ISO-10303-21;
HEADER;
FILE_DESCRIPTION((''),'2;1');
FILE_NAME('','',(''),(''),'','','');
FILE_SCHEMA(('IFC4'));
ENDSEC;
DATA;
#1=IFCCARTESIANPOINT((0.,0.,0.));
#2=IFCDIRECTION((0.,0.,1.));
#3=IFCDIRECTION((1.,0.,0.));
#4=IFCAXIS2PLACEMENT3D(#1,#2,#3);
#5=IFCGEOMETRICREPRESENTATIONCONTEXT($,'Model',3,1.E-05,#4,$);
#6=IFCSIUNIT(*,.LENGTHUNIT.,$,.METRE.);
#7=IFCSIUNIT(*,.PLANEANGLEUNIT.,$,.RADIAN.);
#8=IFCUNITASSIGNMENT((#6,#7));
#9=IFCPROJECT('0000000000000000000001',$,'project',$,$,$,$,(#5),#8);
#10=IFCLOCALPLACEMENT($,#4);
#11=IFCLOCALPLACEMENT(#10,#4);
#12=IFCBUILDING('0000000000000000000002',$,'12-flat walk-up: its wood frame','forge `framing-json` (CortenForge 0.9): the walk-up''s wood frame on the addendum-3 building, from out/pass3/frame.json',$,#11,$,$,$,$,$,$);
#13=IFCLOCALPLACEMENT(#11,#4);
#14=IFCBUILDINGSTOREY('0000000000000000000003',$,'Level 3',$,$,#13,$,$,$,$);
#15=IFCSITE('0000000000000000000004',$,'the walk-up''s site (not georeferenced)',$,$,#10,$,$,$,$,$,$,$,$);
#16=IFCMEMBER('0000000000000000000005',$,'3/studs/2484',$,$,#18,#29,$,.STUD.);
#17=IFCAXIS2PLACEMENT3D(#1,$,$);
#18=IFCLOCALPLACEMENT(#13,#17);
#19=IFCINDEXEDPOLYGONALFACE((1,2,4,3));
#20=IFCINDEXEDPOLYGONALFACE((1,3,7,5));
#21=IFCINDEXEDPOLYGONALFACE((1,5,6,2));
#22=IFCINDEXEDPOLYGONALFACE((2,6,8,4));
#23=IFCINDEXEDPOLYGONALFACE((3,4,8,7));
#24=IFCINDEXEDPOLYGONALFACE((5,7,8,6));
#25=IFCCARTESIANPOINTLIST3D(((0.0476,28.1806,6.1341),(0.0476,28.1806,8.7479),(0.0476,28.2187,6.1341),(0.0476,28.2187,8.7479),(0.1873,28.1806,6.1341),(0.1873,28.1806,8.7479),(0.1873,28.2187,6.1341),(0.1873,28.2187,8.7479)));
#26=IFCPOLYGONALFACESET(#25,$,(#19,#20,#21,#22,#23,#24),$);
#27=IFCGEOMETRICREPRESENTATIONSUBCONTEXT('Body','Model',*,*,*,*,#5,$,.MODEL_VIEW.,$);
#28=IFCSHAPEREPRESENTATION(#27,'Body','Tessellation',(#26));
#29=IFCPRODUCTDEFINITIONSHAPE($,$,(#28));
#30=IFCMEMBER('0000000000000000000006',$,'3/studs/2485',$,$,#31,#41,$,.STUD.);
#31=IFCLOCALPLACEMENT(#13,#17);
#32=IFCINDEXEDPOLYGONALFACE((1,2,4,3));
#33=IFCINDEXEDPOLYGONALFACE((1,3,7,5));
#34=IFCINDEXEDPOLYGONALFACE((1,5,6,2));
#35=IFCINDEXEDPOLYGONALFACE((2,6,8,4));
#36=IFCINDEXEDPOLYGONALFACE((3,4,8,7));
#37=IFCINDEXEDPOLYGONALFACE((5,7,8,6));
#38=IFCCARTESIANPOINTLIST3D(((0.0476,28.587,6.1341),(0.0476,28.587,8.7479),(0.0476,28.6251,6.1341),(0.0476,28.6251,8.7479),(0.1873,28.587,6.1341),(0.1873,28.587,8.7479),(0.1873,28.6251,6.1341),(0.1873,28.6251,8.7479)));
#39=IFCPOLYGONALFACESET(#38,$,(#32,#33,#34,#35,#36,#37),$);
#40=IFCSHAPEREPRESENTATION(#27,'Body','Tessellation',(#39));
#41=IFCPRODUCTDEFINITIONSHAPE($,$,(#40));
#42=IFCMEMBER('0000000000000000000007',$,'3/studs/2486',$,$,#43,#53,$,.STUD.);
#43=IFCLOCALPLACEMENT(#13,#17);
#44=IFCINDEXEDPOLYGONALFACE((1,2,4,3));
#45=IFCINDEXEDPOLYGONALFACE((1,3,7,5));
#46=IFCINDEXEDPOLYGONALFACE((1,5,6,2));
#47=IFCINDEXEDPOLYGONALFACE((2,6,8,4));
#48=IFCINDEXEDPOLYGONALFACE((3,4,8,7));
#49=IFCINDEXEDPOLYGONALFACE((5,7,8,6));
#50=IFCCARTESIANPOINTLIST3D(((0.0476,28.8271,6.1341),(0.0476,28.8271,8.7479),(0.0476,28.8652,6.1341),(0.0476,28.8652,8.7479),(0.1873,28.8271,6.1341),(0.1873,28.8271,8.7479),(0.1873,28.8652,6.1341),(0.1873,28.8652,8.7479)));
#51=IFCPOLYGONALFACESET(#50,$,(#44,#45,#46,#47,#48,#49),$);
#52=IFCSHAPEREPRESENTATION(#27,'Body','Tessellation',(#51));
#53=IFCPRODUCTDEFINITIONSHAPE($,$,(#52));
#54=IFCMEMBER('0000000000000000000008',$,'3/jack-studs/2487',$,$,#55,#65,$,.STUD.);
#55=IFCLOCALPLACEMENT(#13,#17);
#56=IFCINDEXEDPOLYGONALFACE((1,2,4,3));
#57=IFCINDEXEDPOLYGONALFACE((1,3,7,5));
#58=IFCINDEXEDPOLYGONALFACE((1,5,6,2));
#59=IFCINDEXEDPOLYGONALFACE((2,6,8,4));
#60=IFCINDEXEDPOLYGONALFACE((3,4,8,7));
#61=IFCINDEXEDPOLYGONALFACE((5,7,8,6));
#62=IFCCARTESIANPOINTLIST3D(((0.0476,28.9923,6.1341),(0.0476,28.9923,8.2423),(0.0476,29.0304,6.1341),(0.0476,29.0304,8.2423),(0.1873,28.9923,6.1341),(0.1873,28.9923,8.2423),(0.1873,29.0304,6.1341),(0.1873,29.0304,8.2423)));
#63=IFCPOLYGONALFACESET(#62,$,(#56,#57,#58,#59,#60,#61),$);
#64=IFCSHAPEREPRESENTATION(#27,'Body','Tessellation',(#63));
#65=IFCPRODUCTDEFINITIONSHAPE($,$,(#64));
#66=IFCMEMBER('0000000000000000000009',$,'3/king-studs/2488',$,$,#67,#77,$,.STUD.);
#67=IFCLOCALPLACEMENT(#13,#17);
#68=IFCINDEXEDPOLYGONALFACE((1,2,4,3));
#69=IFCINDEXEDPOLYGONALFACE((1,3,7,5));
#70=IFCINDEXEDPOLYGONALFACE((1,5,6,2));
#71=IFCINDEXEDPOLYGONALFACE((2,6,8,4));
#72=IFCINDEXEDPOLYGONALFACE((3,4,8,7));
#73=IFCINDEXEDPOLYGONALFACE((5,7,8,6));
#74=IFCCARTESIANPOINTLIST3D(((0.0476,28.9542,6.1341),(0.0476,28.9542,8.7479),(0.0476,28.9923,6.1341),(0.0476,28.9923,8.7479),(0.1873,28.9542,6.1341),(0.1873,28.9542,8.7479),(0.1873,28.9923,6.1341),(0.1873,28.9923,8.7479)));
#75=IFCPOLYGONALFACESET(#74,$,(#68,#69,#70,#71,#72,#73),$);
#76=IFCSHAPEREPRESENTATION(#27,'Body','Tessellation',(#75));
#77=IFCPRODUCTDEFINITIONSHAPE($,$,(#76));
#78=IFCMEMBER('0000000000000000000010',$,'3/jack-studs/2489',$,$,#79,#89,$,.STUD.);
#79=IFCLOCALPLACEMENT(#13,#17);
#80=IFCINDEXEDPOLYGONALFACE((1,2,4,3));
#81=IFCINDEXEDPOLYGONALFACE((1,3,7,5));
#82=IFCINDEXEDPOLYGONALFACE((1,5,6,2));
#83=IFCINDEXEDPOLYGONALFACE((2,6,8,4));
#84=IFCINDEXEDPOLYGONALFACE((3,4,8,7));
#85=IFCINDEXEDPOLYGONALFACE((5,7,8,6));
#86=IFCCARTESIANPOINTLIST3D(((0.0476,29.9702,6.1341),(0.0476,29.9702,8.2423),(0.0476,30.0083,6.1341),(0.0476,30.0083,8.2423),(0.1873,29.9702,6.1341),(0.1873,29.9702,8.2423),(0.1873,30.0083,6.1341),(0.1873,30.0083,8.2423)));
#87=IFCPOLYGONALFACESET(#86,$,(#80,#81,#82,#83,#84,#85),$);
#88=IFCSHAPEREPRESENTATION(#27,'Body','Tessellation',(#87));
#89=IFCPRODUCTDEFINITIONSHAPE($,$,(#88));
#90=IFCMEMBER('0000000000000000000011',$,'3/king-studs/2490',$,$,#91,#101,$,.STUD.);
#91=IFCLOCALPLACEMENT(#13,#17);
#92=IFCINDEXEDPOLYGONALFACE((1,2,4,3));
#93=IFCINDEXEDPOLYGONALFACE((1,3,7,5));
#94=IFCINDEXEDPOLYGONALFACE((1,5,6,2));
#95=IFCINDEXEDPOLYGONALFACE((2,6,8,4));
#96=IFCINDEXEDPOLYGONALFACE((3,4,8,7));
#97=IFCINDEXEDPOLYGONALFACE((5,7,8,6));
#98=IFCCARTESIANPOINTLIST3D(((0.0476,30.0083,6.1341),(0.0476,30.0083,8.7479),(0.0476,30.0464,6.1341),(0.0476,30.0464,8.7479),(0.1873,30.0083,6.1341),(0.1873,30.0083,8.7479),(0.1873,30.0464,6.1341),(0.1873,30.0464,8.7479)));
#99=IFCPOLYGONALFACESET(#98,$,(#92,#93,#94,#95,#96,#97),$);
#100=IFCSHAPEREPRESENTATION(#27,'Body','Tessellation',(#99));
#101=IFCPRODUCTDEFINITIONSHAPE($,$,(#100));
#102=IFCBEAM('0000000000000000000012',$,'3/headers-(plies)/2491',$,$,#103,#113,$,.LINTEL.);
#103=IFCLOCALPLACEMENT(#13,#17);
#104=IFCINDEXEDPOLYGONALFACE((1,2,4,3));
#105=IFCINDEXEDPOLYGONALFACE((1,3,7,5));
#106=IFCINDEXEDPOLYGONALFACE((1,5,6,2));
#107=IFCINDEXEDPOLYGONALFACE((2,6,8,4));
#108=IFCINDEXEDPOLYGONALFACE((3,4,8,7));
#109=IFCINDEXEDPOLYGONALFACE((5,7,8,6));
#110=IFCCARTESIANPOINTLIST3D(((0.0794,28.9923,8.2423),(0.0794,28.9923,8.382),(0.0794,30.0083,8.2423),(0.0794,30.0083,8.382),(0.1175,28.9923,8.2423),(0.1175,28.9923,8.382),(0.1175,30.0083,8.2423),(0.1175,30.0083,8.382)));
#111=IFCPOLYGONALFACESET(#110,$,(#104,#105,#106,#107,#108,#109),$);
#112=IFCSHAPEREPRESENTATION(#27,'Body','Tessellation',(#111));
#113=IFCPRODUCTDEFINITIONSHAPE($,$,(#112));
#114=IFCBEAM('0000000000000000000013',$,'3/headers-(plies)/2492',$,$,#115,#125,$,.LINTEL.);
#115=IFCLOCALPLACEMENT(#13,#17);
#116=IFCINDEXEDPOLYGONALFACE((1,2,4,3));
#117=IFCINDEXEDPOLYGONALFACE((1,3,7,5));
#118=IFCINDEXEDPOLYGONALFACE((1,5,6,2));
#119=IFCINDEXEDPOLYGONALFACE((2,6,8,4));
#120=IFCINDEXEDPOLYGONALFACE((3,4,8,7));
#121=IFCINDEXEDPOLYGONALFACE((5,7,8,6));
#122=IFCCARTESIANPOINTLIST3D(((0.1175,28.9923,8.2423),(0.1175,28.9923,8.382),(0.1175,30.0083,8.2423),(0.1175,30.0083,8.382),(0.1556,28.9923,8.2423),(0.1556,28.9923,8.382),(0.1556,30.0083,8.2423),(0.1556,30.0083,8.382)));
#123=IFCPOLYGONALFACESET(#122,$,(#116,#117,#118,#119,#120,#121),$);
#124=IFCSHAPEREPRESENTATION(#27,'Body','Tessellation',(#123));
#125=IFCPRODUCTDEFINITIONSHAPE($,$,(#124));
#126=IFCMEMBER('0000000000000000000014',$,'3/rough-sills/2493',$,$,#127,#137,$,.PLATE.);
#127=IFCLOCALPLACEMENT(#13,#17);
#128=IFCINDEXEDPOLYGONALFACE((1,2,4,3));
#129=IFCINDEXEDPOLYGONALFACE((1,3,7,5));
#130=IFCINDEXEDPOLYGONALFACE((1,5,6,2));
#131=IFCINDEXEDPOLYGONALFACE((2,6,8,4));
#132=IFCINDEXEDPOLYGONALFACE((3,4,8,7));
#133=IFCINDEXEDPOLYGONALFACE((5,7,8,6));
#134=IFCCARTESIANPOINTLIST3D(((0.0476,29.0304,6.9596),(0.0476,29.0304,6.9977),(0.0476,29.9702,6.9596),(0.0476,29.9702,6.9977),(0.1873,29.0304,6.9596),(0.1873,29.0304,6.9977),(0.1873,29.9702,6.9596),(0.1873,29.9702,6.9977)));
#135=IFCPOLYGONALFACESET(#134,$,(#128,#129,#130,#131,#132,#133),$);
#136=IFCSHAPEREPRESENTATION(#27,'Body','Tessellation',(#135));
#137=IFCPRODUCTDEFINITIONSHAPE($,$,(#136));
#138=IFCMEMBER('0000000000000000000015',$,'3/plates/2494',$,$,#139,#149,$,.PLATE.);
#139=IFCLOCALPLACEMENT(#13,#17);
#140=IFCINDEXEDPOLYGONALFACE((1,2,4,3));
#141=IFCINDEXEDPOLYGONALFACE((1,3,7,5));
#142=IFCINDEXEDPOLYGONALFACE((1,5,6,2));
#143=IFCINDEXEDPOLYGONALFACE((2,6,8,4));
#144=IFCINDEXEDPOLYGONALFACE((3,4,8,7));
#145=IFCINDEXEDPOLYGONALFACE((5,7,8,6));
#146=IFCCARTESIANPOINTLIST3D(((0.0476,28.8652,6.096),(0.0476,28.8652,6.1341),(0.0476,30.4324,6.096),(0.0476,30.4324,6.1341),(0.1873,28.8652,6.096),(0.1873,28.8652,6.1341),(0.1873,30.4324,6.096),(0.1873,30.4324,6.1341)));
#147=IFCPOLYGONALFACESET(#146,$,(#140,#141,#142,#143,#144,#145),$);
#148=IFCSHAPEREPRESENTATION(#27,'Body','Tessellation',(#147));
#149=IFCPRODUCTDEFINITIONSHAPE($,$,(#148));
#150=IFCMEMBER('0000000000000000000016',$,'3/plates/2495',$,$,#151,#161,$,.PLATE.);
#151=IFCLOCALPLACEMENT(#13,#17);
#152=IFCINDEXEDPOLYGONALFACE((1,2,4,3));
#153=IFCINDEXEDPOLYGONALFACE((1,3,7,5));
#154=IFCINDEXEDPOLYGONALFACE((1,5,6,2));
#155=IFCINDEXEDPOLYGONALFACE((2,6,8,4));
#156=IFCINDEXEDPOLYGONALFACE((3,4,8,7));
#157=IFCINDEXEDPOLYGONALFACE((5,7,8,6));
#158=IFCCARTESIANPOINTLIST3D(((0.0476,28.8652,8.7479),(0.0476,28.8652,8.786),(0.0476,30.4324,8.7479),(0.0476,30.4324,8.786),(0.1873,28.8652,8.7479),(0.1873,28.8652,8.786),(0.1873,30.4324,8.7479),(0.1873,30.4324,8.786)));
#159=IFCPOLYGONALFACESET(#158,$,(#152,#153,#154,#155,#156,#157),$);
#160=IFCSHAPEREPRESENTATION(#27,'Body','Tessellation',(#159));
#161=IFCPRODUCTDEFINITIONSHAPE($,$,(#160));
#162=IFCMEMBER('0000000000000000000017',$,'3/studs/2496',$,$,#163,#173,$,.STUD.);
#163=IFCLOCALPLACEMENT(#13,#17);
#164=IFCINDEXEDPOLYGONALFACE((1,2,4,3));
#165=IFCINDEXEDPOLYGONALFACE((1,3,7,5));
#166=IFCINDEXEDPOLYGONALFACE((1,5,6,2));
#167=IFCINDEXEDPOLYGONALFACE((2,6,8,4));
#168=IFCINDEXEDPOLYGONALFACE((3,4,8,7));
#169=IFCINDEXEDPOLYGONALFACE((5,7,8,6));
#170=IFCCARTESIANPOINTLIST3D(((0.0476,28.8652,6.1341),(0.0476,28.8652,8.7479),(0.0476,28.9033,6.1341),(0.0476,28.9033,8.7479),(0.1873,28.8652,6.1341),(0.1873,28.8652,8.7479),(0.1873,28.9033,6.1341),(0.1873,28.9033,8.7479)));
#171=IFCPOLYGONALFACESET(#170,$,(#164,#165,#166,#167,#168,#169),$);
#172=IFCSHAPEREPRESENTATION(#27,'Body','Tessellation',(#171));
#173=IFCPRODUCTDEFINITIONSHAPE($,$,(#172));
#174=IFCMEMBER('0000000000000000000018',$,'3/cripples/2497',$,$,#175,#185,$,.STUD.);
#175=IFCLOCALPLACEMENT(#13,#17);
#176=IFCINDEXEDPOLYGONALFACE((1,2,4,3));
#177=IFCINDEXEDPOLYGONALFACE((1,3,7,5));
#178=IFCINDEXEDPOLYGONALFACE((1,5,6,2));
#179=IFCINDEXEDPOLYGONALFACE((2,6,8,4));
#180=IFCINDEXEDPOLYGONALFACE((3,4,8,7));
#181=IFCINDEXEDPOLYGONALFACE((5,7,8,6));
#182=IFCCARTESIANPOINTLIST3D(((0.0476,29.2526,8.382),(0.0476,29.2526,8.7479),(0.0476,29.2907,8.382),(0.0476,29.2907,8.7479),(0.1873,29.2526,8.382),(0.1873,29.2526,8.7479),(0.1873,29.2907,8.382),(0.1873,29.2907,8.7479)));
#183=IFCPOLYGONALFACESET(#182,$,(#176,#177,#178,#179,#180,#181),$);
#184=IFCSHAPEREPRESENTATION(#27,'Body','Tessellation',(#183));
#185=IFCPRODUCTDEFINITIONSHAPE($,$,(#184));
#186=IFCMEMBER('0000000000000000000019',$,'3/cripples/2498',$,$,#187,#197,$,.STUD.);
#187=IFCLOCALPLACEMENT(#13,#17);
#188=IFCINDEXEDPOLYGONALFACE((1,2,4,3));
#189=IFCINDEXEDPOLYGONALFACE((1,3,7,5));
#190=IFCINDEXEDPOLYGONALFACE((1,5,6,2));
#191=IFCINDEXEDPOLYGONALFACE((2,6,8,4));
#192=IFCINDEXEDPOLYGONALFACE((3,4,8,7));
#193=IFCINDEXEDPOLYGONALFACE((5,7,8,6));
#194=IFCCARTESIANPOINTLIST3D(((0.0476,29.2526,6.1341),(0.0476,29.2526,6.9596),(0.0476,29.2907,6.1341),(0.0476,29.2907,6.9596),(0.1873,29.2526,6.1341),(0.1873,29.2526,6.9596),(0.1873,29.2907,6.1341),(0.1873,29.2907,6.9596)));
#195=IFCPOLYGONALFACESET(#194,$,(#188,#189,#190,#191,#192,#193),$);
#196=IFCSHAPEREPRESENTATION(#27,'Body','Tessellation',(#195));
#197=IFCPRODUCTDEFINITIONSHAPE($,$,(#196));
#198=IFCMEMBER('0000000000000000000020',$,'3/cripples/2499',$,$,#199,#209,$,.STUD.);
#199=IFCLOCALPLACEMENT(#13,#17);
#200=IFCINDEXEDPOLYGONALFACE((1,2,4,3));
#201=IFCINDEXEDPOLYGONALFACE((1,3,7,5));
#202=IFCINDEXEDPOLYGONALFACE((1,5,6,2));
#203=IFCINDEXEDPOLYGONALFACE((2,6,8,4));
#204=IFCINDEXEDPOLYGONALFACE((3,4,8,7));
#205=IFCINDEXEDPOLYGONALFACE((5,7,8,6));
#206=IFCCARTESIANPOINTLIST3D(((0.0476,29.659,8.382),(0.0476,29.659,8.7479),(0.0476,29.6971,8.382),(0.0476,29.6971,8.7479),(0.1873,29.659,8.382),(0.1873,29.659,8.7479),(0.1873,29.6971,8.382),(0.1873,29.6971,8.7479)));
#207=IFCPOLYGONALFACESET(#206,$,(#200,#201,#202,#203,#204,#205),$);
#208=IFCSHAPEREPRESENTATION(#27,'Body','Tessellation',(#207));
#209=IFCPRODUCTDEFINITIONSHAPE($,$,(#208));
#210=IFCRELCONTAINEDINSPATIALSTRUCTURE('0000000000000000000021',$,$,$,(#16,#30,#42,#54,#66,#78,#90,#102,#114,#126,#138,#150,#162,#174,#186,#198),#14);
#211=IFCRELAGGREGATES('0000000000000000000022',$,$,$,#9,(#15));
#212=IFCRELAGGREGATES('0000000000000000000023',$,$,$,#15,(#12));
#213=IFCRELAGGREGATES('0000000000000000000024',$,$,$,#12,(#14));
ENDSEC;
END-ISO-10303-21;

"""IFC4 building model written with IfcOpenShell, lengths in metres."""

from ifc_helpers import new_model, si_unit, frame, frame_2d, origin, origin_with_axes, place, context, subcontext, project, spatial, rectangle, extrude, element, save


model = new_model("IFC4")

# Units and contexts
model_context = context("Model", 3, precision=1e-05, world=origin_with_axes())
body_context = subcontext(model_context, "Body", "Model", "MODEL_VIEW")
ifc_project = project(units=[si_unit("LENGTHUNIT", "METRE"), si_unit("PLANEANGLEUNIT", "RADIAN")], contexts=[model_context])

# Site, building, storey
site_placement = place(None, origin_with_axes())
site = spatial("IfcSite", under=ifc_project, at=site_placement, Name="the walk-up's site (not georeferenced)")
building_placement = place(site_placement, origin_with_axes())
building = spatial("IfcBuilding", under=site, at=building_placement, Name="12-flat walk-up: its wood frame", Description="forge `framing-json` (CortenForge 0.9): the walk-up's wood frame on the addendum-3 building, from out/pass3/frame.json")
storey_placement = place(building_placement, origin_with_axes())
storey = spatial("IfcBuildingStorey", under=building, at=storey_placement, Name="Level 3")

# Members
for number, where, z_axis, x_axis, name in (
    (1, (0.0476, 28.1806, 6.1341), (0.0, 0.0, 1.0), (1.0, 0.0, 0.0), "3/studs/2484"),
    (2, (0.0476, 28.587, 6.1341), (0.0, 0.0, 1.0), (1.0, 0.0, 0.0), "3/studs/2485"),
    (3, (0.0476, 28.8271, 6.1341), (0.0, 0.0, 1.0), (1.0, 0.0, 0.0), "3/studs/2486"),
):
    element("IfcMember", number, at=place(storey_placement, frame(where, z_axis=z_axis, x_axis=x_axis)), inside=storey, Name=name, PredefinedType="STUD", context=body_context, shape_type="SweptSolid", body=[
        extrude(rectangle(XDim=0.1397, YDim=0.0381, at=frame_2d((0.0698, 0.0191))), origin(), (0.0, 0.0, 1.0), 2.6138),
    ])
member_1_placement = place(storey_placement, frame((0.0476, 28.9923, 6.1341), z_axis=(0.0, 0.0, 1.0), x_axis=(1.0, 0.0, 0.0)))
element("IfcMember", 4, at=member_1_placement, inside=storey, Name="3/jack-studs/2487", PredefinedType="STUD", context=body_context, shape_type="SweptSolid", body=[
    extrude(rectangle(XDim=0.1397, YDim=0.0381, at=frame_2d((0.0698, 0.0191))), origin(), (0.0, 0.0, 1.0), 2.1082),
])
member_2_placement = place(storey_placement, frame((0.0476, 28.9542, 6.1341), z_axis=(0.0, 0.0, 1.0), x_axis=(1.0, 0.0, 0.0)))
element("IfcMember", 5, at=member_2_placement, inside=storey, Name="3/king-studs/2488", PredefinedType="STUD", context=body_context, shape_type="SweptSolid", body=[
    extrude(rectangle(XDim=0.1397, YDim=0.0381, at=frame_2d((0.0698, 0.0191))), origin(), (0.0, 0.0, 1.0), 2.6138),
])
member_3_placement = place(storey_placement, frame((0.0476, 29.9702, 6.1341), z_axis=(0.0, 0.0, 1.0), x_axis=(1.0, 0.0, 0.0)))
element("IfcMember", 6, at=member_3_placement, inside=storey, Name="3/jack-studs/2489", PredefinedType="STUD", context=body_context, shape_type="SweptSolid", body=[
    extrude(rectangle(XDim=0.1397, YDim=0.0381, at=frame_2d((0.0698, 0.019))), origin(), (0.0, 0.0, 1.0), 2.1082),
])
member_4_placement = place(storey_placement, frame((0.0476, 30.0083, 6.1341), z_axis=(0.0, 0.0, 1.0), x_axis=(1.0, 0.0, 0.0)))
element("IfcMember", 7, at=member_4_placement, inside=storey, Name="3/king-studs/2490", PredefinedType="STUD", context=body_context, shape_type="SweptSolid", body=[
    extrude(rectangle(XDim=0.1397, YDim=0.0381, at=frame_2d((0.0698, 0.0191))), origin(), (0.0, 0.0, 1.0), 2.6138),
])

# Beams
for number, where, z_axis, x_axis, name in (
    (8, (0.0794, 28.9923, 8.2423), (0.0, 0.0, 1.0), (1.0, 0.0, 0.0), "3/headers-(plies)/2491"),
    (9, (0.1175, 28.9923, 8.2423), (0.0, 0.0, 1.0), (1.0, 0.0, 0.0), "3/headers-(plies)/2492"),
):
    element("IfcBeam", number, at=place(storey_placement, frame(where, z_axis=z_axis, x_axis=x_axis)), inside=storey, Name=name, PredefinedType="LINTEL", context=body_context, shape_type="SweptSolid", body=[
        extrude(rectangle(XDim=0.0381, YDim=1.016, at=frame_2d((0.019, 0.508))), origin(), (0.0, 0.0, 1.0), 0.1397),
    ])

# Members
member_5_placement = place(storey_placement, frame((0.0476, 29.0304, 6.9596), z_axis=(0.0, 0.0, 1.0), x_axis=(1.0, 0.0, 0.0)))
element("IfcMember", 10, at=member_5_placement, inside=storey, Name="3/rough-sills/2493", PredefinedType="PLATE", context=body_context, shape_type="SweptSolid", body=[
    extrude(rectangle(XDim=0.1397, YDim=0.9398, at=frame_2d((0.0698, 0.4699))), origin(), (0.0, 0.0, 1.0), 0.0381),
])
for number, where, z_axis, x_axis, name in (
    (11, (0.0476, 28.8652, 6.096), (0.0, 0.0, 1.0), (1.0, 0.0, 0.0), "3/plates/2494"),
    (12, (0.0476, 28.8652, 8.7479), (0.0, 0.0, 1.0), (1.0, 0.0, 0.0), "3/plates/2495"),
):
    element("IfcMember", number, at=place(storey_placement, frame(where, z_axis=z_axis, x_axis=x_axis)), inside=storey, Name=name, PredefinedType="PLATE", context=body_context, shape_type="SweptSolid", body=[
        extrude(rectangle(XDim=0.1397, YDim=1.5672, at=frame_2d((0.0698, 0.7836))), origin(), (0.0, 0.0, 1.0), 0.0381),
    ])
member_6_placement = place(storey_placement, frame((0.0476, 28.8652, 6.1341), z_axis=(0.0, 0.0, 1.0), x_axis=(1.0, 0.0, 0.0)))
element("IfcMember", 13, at=member_6_placement, inside=storey, Name="3/studs/2496", PredefinedType="STUD", context=body_context, shape_type="SweptSolid", body=[
    extrude(rectangle(XDim=0.1397, YDim=0.0381, at=frame_2d((0.0698, 0.0191))), origin(), (0.0, 0.0, 1.0), 2.6138),
])
member_7_placement = place(storey_placement, frame((0.0476, 29.2526, 8.382), z_axis=(0.0, 0.0, 1.0), x_axis=(1.0, 0.0, 0.0)))
element("IfcMember", 14, at=member_7_placement, inside=storey, Name="3/cripples/2497", PredefinedType="STUD", context=body_context, shape_type="SweptSolid", body=[
    extrude(rectangle(XDim=0.1397, YDim=0.0381, at=frame_2d((0.0698, 0.0191))), origin(), (0.0, 0.0, 1.0), 0.3659),
])
member_8_placement = place(storey_placement, frame((0.0476, 29.2526, 6.1341), z_axis=(0.0, 0.0, 1.0), x_axis=(1.0, 0.0, 0.0)))
element("IfcMember", 15, at=member_8_placement, inside=storey, Name="3/cripples/2498", PredefinedType="STUD", context=body_context, shape_type="SweptSolid", body=[
    extrude(rectangle(XDim=0.1397, YDim=0.0381, at=frame_2d((0.0698, 0.0191))), origin(), (0.0, 0.0, 1.0), 0.8255),
])
member_9_placement = place(storey_placement, frame((0.0476, 29.659, 8.382), z_axis=(0.0, 0.0, 1.0), x_axis=(1.0, 0.0, 0.0)))
element("IfcMember", 16, at=member_9_placement, inside=storey, Name="3/cripples/2499", PredefinedType="STUD", context=body_context, shape_type="SweptSolid", body=[
    extrude(rectangle(XDim=0.1397, YDim=0.0381, at=frame_2d((0.0698, 0.0191))), origin(), (0.0, 0.0, 1.0), 0.3659),
])

save(model, "model.ifc")
